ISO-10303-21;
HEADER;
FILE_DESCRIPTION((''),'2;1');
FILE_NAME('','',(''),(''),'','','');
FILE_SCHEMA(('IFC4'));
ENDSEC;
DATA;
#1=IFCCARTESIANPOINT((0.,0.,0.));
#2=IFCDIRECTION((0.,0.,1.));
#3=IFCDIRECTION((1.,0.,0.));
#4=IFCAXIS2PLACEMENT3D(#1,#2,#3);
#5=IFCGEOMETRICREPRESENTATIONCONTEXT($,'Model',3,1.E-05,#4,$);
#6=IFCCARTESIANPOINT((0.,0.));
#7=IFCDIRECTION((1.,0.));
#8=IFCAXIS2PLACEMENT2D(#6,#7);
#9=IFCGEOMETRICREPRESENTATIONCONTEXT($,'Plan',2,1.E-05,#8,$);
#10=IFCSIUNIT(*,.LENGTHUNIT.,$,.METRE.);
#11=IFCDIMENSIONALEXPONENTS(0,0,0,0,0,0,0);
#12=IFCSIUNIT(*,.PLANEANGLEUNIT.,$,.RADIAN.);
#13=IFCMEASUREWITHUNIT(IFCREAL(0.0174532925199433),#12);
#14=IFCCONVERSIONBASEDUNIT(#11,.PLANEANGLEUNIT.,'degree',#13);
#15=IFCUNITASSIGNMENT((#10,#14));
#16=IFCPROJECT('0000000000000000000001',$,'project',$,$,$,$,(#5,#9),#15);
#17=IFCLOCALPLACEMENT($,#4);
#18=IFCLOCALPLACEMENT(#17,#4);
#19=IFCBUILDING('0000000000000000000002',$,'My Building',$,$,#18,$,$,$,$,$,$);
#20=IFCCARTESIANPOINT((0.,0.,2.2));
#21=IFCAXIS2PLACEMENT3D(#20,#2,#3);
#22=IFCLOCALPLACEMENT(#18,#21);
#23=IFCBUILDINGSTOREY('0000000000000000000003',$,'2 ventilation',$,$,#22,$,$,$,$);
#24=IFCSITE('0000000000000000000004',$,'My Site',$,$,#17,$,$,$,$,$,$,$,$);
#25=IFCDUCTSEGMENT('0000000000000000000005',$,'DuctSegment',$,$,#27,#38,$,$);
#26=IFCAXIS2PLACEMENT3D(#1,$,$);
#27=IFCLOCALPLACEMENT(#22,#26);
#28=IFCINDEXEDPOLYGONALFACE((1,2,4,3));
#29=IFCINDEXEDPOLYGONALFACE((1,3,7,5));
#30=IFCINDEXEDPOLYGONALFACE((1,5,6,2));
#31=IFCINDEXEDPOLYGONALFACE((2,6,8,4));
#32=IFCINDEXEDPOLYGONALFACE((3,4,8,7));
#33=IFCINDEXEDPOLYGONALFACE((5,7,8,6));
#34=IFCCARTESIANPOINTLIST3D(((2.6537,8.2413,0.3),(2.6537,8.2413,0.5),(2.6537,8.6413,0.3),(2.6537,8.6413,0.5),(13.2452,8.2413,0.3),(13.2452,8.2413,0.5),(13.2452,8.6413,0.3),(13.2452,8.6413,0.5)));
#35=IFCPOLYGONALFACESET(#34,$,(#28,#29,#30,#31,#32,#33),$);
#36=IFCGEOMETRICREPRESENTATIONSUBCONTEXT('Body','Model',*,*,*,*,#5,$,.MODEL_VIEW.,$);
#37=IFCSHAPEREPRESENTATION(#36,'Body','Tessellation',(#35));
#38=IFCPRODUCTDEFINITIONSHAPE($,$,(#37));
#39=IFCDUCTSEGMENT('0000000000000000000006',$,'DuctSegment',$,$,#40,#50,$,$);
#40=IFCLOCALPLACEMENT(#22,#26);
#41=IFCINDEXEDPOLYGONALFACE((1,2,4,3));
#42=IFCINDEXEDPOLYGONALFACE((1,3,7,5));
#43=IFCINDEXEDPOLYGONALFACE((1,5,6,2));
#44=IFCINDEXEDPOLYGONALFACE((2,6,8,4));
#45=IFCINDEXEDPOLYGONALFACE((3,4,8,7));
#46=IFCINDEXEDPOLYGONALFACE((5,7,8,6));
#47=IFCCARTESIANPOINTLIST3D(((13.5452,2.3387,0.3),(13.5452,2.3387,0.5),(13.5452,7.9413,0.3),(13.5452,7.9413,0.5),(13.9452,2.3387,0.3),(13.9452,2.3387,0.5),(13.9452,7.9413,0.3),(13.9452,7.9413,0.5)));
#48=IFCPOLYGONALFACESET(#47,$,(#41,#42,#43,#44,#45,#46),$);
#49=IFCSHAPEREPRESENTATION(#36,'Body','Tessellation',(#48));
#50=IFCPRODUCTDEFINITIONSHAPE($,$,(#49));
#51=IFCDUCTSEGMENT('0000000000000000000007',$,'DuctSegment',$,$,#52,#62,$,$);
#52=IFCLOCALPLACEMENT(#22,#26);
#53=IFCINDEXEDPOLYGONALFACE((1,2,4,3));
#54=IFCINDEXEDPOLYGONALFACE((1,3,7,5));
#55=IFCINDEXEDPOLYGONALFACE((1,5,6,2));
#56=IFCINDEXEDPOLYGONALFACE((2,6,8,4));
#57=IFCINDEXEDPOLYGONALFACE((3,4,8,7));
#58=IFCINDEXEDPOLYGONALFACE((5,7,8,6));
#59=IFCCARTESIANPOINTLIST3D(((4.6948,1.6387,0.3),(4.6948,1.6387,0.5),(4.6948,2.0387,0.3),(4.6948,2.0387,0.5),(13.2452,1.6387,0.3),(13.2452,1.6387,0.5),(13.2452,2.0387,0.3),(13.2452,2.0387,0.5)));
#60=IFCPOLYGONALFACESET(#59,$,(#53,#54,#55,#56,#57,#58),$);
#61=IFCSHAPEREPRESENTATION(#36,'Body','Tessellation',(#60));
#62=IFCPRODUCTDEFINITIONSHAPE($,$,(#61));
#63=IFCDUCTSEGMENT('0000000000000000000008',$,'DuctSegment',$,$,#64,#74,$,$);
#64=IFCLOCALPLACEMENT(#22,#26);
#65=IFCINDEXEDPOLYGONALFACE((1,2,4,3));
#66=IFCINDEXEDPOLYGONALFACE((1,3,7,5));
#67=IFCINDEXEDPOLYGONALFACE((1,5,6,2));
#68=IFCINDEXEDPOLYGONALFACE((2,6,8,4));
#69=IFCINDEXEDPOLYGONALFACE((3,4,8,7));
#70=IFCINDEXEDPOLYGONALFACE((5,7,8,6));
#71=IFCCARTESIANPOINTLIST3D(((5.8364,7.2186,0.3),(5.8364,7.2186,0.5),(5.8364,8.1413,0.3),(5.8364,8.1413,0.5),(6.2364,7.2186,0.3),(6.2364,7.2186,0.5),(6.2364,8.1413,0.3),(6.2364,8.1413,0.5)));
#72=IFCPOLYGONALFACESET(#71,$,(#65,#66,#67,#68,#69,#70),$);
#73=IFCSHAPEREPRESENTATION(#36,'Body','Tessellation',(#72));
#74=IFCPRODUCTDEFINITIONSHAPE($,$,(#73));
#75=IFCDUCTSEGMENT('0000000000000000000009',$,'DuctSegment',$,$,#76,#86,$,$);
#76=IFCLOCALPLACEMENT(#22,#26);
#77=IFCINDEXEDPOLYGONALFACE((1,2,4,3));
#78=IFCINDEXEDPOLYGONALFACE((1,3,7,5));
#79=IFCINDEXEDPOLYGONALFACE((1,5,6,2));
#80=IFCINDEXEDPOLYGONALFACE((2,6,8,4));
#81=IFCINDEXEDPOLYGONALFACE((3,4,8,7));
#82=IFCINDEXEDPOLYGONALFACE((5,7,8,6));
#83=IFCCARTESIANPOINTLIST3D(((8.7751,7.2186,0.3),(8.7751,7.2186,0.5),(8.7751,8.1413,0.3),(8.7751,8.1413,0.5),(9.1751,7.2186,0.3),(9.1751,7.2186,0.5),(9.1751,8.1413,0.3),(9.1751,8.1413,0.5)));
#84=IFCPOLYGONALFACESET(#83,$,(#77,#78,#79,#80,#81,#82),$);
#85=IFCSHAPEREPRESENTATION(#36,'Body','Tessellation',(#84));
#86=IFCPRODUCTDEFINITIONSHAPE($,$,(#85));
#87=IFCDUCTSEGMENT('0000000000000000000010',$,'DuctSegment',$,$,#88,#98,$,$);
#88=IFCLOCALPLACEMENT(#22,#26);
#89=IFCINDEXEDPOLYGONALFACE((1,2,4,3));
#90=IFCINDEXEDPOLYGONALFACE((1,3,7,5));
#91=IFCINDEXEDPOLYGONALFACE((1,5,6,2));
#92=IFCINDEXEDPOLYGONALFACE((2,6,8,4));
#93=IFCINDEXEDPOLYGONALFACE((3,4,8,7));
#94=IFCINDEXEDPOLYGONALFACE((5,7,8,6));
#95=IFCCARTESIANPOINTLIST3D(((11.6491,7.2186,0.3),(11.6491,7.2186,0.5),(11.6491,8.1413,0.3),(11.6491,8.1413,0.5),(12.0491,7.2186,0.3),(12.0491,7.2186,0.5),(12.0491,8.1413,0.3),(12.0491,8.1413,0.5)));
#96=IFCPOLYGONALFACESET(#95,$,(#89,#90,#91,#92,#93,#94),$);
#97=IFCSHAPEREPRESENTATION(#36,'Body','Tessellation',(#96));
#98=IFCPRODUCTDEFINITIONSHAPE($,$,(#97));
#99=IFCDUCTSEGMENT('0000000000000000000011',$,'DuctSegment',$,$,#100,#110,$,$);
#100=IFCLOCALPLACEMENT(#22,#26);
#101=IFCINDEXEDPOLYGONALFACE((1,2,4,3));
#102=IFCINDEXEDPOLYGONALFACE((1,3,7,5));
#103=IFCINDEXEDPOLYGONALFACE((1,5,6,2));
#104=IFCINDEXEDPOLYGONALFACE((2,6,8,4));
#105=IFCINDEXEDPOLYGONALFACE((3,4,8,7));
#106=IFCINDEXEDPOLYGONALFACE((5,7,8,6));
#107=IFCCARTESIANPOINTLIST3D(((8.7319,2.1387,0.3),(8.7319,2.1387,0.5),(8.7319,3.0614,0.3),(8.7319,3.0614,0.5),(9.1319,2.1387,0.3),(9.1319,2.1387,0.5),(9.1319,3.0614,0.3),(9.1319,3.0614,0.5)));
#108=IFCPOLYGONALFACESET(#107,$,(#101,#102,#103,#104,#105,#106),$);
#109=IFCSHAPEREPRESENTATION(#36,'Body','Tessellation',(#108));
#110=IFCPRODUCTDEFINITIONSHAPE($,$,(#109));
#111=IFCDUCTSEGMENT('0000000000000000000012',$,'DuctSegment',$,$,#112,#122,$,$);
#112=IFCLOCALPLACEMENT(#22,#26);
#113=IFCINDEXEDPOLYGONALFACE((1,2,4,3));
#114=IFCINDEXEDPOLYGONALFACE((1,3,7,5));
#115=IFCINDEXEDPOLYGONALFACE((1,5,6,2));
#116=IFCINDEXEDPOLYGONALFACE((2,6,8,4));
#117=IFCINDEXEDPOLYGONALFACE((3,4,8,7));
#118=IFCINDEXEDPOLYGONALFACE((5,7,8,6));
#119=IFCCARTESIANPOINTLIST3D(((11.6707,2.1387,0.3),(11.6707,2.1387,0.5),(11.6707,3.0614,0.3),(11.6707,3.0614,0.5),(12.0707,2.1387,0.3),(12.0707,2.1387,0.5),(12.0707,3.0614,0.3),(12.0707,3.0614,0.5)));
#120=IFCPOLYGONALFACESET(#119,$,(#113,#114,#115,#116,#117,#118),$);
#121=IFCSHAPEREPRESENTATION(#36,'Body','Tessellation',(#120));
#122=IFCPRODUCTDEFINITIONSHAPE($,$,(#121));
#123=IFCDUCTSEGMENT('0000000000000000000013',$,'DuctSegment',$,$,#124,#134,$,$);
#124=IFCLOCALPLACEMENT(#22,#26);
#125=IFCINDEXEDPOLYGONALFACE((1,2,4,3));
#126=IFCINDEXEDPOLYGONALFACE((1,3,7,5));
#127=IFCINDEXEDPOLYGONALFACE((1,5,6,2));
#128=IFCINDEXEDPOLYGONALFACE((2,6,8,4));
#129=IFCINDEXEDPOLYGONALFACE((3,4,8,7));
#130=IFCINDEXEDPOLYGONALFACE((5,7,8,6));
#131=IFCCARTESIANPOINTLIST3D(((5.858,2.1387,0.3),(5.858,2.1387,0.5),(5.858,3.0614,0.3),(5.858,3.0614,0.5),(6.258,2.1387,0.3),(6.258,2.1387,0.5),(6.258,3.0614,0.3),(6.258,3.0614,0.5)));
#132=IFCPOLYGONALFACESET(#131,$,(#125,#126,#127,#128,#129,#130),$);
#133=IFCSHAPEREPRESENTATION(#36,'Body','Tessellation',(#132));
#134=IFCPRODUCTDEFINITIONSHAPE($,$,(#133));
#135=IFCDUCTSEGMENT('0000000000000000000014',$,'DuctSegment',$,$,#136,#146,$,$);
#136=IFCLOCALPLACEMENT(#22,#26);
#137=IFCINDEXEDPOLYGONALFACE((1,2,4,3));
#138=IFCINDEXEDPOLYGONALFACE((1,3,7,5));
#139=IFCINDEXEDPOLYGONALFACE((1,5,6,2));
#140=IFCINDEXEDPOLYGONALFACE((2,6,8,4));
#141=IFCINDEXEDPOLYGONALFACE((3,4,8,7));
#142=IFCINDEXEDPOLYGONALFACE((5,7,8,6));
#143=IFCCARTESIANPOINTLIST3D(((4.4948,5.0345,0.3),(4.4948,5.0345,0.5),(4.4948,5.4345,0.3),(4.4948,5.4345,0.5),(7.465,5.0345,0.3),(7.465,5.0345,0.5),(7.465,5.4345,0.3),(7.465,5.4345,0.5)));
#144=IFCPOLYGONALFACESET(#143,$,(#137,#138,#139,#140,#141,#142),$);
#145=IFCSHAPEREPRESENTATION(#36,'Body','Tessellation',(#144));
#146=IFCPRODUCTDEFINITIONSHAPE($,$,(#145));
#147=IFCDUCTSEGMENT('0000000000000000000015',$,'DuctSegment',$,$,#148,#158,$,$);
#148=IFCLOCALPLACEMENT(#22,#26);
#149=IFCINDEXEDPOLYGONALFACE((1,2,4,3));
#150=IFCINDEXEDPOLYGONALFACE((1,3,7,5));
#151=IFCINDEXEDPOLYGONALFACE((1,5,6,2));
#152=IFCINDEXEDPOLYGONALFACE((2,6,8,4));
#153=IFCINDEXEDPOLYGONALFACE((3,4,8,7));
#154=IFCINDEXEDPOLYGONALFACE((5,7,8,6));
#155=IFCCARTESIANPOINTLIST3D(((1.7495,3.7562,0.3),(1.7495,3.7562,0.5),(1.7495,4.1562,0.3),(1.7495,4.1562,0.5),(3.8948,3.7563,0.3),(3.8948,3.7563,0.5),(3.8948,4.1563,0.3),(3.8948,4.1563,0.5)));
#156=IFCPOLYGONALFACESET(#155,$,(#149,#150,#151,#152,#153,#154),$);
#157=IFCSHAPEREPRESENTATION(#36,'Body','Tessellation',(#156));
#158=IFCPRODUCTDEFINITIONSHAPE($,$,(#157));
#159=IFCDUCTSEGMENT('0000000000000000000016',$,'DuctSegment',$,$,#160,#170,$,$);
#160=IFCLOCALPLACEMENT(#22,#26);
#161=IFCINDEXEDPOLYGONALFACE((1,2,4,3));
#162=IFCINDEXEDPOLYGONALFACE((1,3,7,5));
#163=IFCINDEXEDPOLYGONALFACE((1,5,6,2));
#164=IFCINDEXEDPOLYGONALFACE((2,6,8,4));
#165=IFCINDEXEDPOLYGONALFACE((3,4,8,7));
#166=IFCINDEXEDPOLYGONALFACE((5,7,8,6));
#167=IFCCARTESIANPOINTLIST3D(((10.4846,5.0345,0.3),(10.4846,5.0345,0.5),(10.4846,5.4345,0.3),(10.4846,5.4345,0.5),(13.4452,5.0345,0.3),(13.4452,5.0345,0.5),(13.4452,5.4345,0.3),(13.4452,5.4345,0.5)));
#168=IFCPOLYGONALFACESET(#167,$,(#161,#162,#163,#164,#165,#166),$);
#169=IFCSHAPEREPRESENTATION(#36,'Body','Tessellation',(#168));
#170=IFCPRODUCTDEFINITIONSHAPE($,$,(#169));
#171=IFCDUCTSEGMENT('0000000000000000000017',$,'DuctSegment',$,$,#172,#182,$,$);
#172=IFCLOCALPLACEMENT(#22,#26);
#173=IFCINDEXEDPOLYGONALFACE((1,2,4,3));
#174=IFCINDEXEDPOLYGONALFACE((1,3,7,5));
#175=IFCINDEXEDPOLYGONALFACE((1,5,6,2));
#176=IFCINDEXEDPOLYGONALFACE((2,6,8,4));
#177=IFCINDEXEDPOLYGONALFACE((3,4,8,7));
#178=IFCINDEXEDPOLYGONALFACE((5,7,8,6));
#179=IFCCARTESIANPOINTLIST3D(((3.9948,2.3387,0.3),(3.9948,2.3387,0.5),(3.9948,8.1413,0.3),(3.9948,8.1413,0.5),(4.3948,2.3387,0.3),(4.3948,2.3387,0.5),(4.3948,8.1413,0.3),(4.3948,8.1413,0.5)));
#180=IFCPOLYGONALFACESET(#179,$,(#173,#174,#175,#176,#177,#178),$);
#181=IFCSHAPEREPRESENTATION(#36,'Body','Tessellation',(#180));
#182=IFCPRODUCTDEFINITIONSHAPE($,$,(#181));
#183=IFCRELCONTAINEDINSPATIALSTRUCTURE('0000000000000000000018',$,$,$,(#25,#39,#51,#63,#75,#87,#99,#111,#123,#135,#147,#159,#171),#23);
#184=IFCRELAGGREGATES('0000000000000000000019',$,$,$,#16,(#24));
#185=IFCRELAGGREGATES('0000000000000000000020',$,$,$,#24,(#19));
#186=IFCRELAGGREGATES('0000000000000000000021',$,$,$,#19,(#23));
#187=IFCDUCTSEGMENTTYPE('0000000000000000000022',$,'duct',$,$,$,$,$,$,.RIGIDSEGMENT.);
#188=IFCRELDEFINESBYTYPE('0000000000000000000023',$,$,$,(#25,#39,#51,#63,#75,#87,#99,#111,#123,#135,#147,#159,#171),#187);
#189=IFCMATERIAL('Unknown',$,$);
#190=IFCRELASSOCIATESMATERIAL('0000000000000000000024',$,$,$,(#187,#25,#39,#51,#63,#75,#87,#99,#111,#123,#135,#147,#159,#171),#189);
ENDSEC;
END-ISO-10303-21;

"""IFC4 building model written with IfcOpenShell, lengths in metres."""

from ifc_helpers import new_model, entity, si_unit, converted_unit, frame, origin_with_axes, origin_2d_with_axis, place, context, subcontext, project, spatial, indexed_curve, outline, extrude, material, material_profile, profile_set, profile_usage, type_object, element, save


model = new_model("IFC4")

# Units and contexts
model_context = context("Model", 3, precision=1e-05, world=origin_with_axes())
plan_context = context("Plan", 2, precision=1e-05, world=origin_2d_with_axis())
body_context = subcontext(model_context, "Body", "Model", "MODEL_VIEW")
ifc_project = project(units=[si_unit("LENGTHUNIT", "METRE"), converted_unit("PLANEANGLEUNIT", "degree", entity("IfcReal", 0.0174532925199433), si_unit("PLANEANGLEUNIT", "RADIAN"), dimensions=[0, 0, 0, 0, 0, 0, 0])], contexts=[model_context, plan_context])

# Site, building, storey
site_placement = place(None, origin_with_axes())
site = spatial("IfcSite", under=ifc_project, at=site_placement, Name="My Site")
building_placement = place(site_placement, origin_with_axes())
building = spatial("IfcBuilding", under=site, at=building_placement, Name="My Building")
storey_placement = place(building_placement, frame((0.0, 0.0, 2.2), z_axis=(0.0, 0.0, 1.0), x_axis=(1.0, 0.0, 0.0)))
storey = spatial("IfcBuildingStorey", under=building, at=storey_placement, Name="2 ventilation")

# Duct segments
ifc_material = material(Name="Unknown")
ifc_material_profile_1 = material_profile(ifc_material, outline(indexed_curve([(-0.2, 0.1), (0.2, 0.1), (0.2, -0.1), (-0.2, -0.1), (-0.2, 0.1)])))
ifc_profile_set_1 = profile_set([ifc_material_profile_1])
ifc_profile_usage_1 = profile_usage(ifc_profile_set_1, cardinal=5)
duct_segment_type = type_object("IfcDuctSegmentType", Name="duct", PredefinedType="RIGIDSEGMENT", material=ifc_profile_set_1)
duct_segment_1_placement = place(storey_placement, frame((2.6537, 8.4413, 0.4), z_axis=(1.0, 0.0, 0.0), x_axis=(0.0, 1.0, 0.0)))
element("IfcDuctSegment", 1, at=duct_segment_1_placement, inside=storey, type_object=duct_segment_type, material=ifc_profile_usage_1, Name="DuctSegment", context=body_context, shape_type="SweptSolid", body=[
    extrude(outline(indexed_curve([(-0.2, 0.1), (0.2, 0.1), (0.2, -0.1), (-0.2, -0.1), (-0.2, 0.1)])), origin_with_axes(), (0.0, 0.0, 1.0), 10.5915),
])
ifc_profile_usage_2 = profile_usage(ifc_profile_set_1, cardinal=5)
duct_segment_2_placement = place(storey_placement, frame((13.7452, 2.3387, 0.4), z_axis=(0.0, 1.0, 0.000001), x_axis=(-1.0, 0.0, 0.0)))
element("IfcDuctSegment", 2, at=duct_segment_2_placement, inside=storey, type_object=duct_segment_type, material=ifc_profile_usage_2, Name="DuctSegment", context=body_context, shape_type="SweptSolid", body=[
    extrude(outline(indexed_curve([(-0.2, 0.1), (0.2, 0.1), (0.2, -0.1), (-0.2, -0.1), (-0.2, 0.1)])), origin_with_axes(), (0.0, 0.0, 1.0), 5.6026),
])
ifc_profile_usage_3 = profile_usage(ifc_profile_set_1, cardinal=5)
duct_segment_3_placement = place(storey_placement, frame((4.6948, 1.8387, 0.4), z_axis=(1.0, 0.0, 0.0), x_axis=(0.0, 1.0, 0.0)))
element("IfcDuctSegment", 3, at=duct_segment_3_placement, inside=storey, type_object=duct_segment_type, material=ifc_profile_usage_3, Name="DuctSegment", context=body_context, shape_type="SweptSolid", body=[
    extrude(outline(indexed_curve([(-0.2, 0.1), (0.2, 0.1), (0.2, -0.1), (-0.2, -0.1), (-0.2, 0.1)])), origin_with_axes(), (0.0, 0.0, 1.0), 8.5504),
])
ifc_profile_usage_4 = profile_usage(ifc_profile_set_1, cardinal=2)
duct_segment_4_placement = place(storey_placement, frame((6.0364, 7.2186, 0.3), z_axis=(0.0, 1.0, 0.000007), x_axis=(-1.0, 0.0, 0.0)))
element("IfcDuctSegment", 4, at=duct_segment_4_placement, inside=storey, type_object=duct_segment_type, material=ifc_profile_usage_4, Name="DuctSegment", context=body_context, shape_type="SweptSolid", body=[
    extrude(outline(indexed_curve([(-0.2, 0.1), (0.2, 0.1), (0.2, -0.1), (-0.2, -0.1), (-0.2, 0.1)])), frame((0.0, 0.1, 0.0), z_axis=(0.0, 0.0, 1.0), x_axis=(1.0, 0.0, 0.0)), (0.0, 0.0, 1.0), 0.9227),
])
ifc_profile_usage_5 = profile_usage(ifc_profile_set_1, cardinal=2)
duct_segment_5_placement = place(storey_placement, frame((8.9751, 7.2186, 0.3), z_axis=(0.0, 1.0, 0.000007), x_axis=(-1.0, 0.0, 0.0)))
element("IfcDuctSegment", 5, at=duct_segment_5_placement, inside=storey, type_object=duct_segment_type, material=ifc_profile_usage_5, Name="DuctSegment", context=body_context, shape_type="SweptSolid", body=[
    extrude(outline(indexed_curve([(-0.2, 0.1), (0.2, 0.1), (0.2, -0.1), (-0.2, -0.1), (-0.2, 0.1)])), frame((0.0, 0.1, 0.0), z_axis=(0.0, 0.0, 1.0), x_axis=(1.0, 0.0, 0.0)), (0.0, 0.0, 1.0), 0.9227),
])
ifc_profile_usage_6 = profile_usage(ifc_profile_set_1, cardinal=2)
duct_segment_6_placement = place(storey_placement, frame((11.8491, 7.2186, 0.3), z_axis=(0.0, 1.0, 0.000007), x_axis=(-1.0, 0.0, 0.0)))
element("IfcDuctSegment", 6, at=duct_segment_6_placement, inside=storey, type_object=duct_segment_type, material=ifc_profile_usage_6, Name="DuctSegment", context=body_context, shape_type="SweptSolid", body=[
    extrude(outline(indexed_curve([(-0.2, 0.1), (0.2, 0.1), (0.2, -0.1), (-0.2, -0.1), (-0.2, 0.1)])), frame((0.0, 0.1, 0.0), z_axis=(0.0, 0.0, 1.0), x_axis=(1.0, 0.0, 0.0)), (0.0, 0.0, 1.0), 0.9227),
])
ifc_profile_usage_7 = profile_usage(ifc_profile_set_1, cardinal=2)
duct_segment_7_placement = place(storey_placement, frame((8.9319, 3.0614, 0.3), z_axis=(0.0, -1.0, 0.000007), x_axis=(1.0, 0.0, 0.0)))
element("IfcDuctSegment", 7, at=duct_segment_7_placement, inside=storey, type_object=duct_segment_type, material=ifc_profile_usage_7, Name="DuctSegment", context=body_context, shape_type="SweptSolid", body=[
    extrude(outline(indexed_curve([(-0.2, 0.1), (0.2, 0.1), (0.2, -0.1), (-0.2, -0.1), (-0.2, 0.1)])), frame((0.0, 0.1, 0.0), z_axis=(0.0, 0.0, 1.0), x_axis=(1.0, 0.0, 0.0)), (0.0, 0.0, 1.0), 0.9227),
])
ifc_profile_usage_8 = profile_usage(ifc_profile_set_1, cardinal=2)
duct_segment_8_placement = place(storey_placement, frame((11.8707, 3.0614, 0.3), z_axis=(0.0, -1.0, 0.000007), x_axis=(1.0, 0.0, 0.0)))
element("IfcDuctSegment", 8, at=duct_segment_8_placement, inside=storey, type_object=duct_segment_type, material=ifc_profile_usage_8, Name="DuctSegment", context=body_context, shape_type="SweptSolid", body=[
    extrude(outline(indexed_curve([(-0.2, 0.1), (0.2, 0.1), (0.2, -0.1), (-0.2, -0.1), (-0.2, 0.1)])), frame((0.0, 0.1, 0.0), z_axis=(0.0, 0.0, 1.0), x_axis=(1.0, 0.0, 0.0)), (0.0, 0.0, 1.0), 0.9227),
])
ifc_profile_usage_9 = profile_usage(ifc_profile_set_1, cardinal=2)
duct_segment_9_placement = place(storey_placement, frame((6.058, 3.0614, 0.3), z_axis=(0.0, -1.0, 0.000007), x_axis=(1.0, 0.0, 0.0)))
element("IfcDuctSegment", 9, at=duct_segment_9_placement, inside=storey, type_object=duct_segment_type, material=ifc_profile_usage_9, Name="DuctSegment", context=body_context, shape_type="SweptSolid", body=[
    extrude(outline(indexed_curve([(-0.2, 0.1), (0.2, 0.1), (0.2, -0.1), (-0.2, -0.1), (-0.2, 0.1)])), frame((0.0, 0.1, 0.0), z_axis=(0.0, 0.0, 1.0), x_axis=(1.0, 0.0, 0.0)), (0.0, 0.0, 1.0), 0.9227),
])
ifc_profile_usage_10 = profile_usage(ifc_profile_set_1, cardinal=2)
duct_segment_10_placement = place(storey_placement, frame((7.465, 5.2345, 0.3), z_axis=(-1.0, -0.000001, 0.000007), x_axis=(0.000001, -1.0, 0.0)))
element("IfcDuctSegment", 10, at=duct_segment_10_placement, inside=storey, type_object=duct_segment_type, material=ifc_profile_usage_10, Name="DuctSegment", context=body_context, shape_type="SweptSolid", body=[
    extrude(outline(indexed_curve([(-0.2, 0.1), (0.2, 0.1), (0.2, -0.1), (-0.2, -0.1), (-0.2, 0.1)])), frame((0.0, 0.1, 0.0), z_axis=(0.0, 0.0, 1.0), x_axis=(1.0, 0.0, 0.0)), (0.0, 0.0, 1.0), 2.9702),
])
ifc_profile_usage_11 = profile_usage(ifc_profile_set_1, cardinal=2)
duct_segment_11_placement = place(storey_placement, frame((1.7495, 3.9562, 0.3), z_axis=(1.0, 0.000001, 0.000007), x_axis=(-0.000001, 1.0, 0.0)))
element("IfcDuctSegment", 11, at=duct_segment_11_placement, inside=storey, type_object=duct_segment_type, material=ifc_profile_usage_11, Name="DuctSegment", context=body_context, shape_type="SweptSolid", body=[
    extrude(outline(indexed_curve([(-0.2, 0.1), (0.2, 0.1), (0.2, -0.1), (-0.2, -0.1), (-0.2, 0.1)])), frame((0.0, 0.1, 0.0), z_axis=(0.0, 0.0, 1.0), x_axis=(1.0, 0.0, 0.0)), (0.0, 0.0, 1.0), 2.1453),
])
ifc_profile_usage_12 = profile_usage(ifc_profile_set_1, cardinal=2)
duct_segment_12_placement = place(storey_placement, frame((13.4452, 5.2345, 0.3), z_axis=(-1.0, -0.000001, 0.000007), x_axis=(0.000001, -1.0, 0.0)))
element("IfcDuctSegment", 12, at=duct_segment_12_placement, inside=storey, type_object=duct_segment_type, material=ifc_profile_usage_12, Name="DuctSegment", context=body_context, shape_type="SweptSolid", body=[
    extrude(outline(indexed_curve([(-0.2, 0.1), (0.2, 0.1), (0.2, -0.1), (-0.2, -0.1), (-0.2, 0.1)])), frame((0.0, 0.1, 0.0), z_axis=(0.0, 0.0, 1.0), x_axis=(1.0, 0.0, 0.0)), (0.0, 0.0, 1.0), 2.9606),
])
ifc_profile_usage_13 = profile_usage(ifc_profile_set_1, cardinal=5)
duct_segment_13_placement = place(storey_placement, frame((4.1948, 8.1413, 0.4), z_axis=(0.0, -1.0, 0.000001), x_axis=(1.0, 0.0, 0.0)))
element("IfcDuctSegment", 13, at=duct_segment_13_placement, inside=storey, type_object=duct_segment_type, material=ifc_profile_usage_13, Name="DuctSegment", context=body_context, shape_type="SweptSolid", body=[
    extrude(outline(indexed_curve([(-0.2, 0.1), (0.2, 0.1), (0.2, -0.1), (-0.2, -0.1), (-0.2, 0.1)])), origin_with_axes(), (0.0, 0.0, 1.0), 5.8026),
])

save(model, "model.ifc")
